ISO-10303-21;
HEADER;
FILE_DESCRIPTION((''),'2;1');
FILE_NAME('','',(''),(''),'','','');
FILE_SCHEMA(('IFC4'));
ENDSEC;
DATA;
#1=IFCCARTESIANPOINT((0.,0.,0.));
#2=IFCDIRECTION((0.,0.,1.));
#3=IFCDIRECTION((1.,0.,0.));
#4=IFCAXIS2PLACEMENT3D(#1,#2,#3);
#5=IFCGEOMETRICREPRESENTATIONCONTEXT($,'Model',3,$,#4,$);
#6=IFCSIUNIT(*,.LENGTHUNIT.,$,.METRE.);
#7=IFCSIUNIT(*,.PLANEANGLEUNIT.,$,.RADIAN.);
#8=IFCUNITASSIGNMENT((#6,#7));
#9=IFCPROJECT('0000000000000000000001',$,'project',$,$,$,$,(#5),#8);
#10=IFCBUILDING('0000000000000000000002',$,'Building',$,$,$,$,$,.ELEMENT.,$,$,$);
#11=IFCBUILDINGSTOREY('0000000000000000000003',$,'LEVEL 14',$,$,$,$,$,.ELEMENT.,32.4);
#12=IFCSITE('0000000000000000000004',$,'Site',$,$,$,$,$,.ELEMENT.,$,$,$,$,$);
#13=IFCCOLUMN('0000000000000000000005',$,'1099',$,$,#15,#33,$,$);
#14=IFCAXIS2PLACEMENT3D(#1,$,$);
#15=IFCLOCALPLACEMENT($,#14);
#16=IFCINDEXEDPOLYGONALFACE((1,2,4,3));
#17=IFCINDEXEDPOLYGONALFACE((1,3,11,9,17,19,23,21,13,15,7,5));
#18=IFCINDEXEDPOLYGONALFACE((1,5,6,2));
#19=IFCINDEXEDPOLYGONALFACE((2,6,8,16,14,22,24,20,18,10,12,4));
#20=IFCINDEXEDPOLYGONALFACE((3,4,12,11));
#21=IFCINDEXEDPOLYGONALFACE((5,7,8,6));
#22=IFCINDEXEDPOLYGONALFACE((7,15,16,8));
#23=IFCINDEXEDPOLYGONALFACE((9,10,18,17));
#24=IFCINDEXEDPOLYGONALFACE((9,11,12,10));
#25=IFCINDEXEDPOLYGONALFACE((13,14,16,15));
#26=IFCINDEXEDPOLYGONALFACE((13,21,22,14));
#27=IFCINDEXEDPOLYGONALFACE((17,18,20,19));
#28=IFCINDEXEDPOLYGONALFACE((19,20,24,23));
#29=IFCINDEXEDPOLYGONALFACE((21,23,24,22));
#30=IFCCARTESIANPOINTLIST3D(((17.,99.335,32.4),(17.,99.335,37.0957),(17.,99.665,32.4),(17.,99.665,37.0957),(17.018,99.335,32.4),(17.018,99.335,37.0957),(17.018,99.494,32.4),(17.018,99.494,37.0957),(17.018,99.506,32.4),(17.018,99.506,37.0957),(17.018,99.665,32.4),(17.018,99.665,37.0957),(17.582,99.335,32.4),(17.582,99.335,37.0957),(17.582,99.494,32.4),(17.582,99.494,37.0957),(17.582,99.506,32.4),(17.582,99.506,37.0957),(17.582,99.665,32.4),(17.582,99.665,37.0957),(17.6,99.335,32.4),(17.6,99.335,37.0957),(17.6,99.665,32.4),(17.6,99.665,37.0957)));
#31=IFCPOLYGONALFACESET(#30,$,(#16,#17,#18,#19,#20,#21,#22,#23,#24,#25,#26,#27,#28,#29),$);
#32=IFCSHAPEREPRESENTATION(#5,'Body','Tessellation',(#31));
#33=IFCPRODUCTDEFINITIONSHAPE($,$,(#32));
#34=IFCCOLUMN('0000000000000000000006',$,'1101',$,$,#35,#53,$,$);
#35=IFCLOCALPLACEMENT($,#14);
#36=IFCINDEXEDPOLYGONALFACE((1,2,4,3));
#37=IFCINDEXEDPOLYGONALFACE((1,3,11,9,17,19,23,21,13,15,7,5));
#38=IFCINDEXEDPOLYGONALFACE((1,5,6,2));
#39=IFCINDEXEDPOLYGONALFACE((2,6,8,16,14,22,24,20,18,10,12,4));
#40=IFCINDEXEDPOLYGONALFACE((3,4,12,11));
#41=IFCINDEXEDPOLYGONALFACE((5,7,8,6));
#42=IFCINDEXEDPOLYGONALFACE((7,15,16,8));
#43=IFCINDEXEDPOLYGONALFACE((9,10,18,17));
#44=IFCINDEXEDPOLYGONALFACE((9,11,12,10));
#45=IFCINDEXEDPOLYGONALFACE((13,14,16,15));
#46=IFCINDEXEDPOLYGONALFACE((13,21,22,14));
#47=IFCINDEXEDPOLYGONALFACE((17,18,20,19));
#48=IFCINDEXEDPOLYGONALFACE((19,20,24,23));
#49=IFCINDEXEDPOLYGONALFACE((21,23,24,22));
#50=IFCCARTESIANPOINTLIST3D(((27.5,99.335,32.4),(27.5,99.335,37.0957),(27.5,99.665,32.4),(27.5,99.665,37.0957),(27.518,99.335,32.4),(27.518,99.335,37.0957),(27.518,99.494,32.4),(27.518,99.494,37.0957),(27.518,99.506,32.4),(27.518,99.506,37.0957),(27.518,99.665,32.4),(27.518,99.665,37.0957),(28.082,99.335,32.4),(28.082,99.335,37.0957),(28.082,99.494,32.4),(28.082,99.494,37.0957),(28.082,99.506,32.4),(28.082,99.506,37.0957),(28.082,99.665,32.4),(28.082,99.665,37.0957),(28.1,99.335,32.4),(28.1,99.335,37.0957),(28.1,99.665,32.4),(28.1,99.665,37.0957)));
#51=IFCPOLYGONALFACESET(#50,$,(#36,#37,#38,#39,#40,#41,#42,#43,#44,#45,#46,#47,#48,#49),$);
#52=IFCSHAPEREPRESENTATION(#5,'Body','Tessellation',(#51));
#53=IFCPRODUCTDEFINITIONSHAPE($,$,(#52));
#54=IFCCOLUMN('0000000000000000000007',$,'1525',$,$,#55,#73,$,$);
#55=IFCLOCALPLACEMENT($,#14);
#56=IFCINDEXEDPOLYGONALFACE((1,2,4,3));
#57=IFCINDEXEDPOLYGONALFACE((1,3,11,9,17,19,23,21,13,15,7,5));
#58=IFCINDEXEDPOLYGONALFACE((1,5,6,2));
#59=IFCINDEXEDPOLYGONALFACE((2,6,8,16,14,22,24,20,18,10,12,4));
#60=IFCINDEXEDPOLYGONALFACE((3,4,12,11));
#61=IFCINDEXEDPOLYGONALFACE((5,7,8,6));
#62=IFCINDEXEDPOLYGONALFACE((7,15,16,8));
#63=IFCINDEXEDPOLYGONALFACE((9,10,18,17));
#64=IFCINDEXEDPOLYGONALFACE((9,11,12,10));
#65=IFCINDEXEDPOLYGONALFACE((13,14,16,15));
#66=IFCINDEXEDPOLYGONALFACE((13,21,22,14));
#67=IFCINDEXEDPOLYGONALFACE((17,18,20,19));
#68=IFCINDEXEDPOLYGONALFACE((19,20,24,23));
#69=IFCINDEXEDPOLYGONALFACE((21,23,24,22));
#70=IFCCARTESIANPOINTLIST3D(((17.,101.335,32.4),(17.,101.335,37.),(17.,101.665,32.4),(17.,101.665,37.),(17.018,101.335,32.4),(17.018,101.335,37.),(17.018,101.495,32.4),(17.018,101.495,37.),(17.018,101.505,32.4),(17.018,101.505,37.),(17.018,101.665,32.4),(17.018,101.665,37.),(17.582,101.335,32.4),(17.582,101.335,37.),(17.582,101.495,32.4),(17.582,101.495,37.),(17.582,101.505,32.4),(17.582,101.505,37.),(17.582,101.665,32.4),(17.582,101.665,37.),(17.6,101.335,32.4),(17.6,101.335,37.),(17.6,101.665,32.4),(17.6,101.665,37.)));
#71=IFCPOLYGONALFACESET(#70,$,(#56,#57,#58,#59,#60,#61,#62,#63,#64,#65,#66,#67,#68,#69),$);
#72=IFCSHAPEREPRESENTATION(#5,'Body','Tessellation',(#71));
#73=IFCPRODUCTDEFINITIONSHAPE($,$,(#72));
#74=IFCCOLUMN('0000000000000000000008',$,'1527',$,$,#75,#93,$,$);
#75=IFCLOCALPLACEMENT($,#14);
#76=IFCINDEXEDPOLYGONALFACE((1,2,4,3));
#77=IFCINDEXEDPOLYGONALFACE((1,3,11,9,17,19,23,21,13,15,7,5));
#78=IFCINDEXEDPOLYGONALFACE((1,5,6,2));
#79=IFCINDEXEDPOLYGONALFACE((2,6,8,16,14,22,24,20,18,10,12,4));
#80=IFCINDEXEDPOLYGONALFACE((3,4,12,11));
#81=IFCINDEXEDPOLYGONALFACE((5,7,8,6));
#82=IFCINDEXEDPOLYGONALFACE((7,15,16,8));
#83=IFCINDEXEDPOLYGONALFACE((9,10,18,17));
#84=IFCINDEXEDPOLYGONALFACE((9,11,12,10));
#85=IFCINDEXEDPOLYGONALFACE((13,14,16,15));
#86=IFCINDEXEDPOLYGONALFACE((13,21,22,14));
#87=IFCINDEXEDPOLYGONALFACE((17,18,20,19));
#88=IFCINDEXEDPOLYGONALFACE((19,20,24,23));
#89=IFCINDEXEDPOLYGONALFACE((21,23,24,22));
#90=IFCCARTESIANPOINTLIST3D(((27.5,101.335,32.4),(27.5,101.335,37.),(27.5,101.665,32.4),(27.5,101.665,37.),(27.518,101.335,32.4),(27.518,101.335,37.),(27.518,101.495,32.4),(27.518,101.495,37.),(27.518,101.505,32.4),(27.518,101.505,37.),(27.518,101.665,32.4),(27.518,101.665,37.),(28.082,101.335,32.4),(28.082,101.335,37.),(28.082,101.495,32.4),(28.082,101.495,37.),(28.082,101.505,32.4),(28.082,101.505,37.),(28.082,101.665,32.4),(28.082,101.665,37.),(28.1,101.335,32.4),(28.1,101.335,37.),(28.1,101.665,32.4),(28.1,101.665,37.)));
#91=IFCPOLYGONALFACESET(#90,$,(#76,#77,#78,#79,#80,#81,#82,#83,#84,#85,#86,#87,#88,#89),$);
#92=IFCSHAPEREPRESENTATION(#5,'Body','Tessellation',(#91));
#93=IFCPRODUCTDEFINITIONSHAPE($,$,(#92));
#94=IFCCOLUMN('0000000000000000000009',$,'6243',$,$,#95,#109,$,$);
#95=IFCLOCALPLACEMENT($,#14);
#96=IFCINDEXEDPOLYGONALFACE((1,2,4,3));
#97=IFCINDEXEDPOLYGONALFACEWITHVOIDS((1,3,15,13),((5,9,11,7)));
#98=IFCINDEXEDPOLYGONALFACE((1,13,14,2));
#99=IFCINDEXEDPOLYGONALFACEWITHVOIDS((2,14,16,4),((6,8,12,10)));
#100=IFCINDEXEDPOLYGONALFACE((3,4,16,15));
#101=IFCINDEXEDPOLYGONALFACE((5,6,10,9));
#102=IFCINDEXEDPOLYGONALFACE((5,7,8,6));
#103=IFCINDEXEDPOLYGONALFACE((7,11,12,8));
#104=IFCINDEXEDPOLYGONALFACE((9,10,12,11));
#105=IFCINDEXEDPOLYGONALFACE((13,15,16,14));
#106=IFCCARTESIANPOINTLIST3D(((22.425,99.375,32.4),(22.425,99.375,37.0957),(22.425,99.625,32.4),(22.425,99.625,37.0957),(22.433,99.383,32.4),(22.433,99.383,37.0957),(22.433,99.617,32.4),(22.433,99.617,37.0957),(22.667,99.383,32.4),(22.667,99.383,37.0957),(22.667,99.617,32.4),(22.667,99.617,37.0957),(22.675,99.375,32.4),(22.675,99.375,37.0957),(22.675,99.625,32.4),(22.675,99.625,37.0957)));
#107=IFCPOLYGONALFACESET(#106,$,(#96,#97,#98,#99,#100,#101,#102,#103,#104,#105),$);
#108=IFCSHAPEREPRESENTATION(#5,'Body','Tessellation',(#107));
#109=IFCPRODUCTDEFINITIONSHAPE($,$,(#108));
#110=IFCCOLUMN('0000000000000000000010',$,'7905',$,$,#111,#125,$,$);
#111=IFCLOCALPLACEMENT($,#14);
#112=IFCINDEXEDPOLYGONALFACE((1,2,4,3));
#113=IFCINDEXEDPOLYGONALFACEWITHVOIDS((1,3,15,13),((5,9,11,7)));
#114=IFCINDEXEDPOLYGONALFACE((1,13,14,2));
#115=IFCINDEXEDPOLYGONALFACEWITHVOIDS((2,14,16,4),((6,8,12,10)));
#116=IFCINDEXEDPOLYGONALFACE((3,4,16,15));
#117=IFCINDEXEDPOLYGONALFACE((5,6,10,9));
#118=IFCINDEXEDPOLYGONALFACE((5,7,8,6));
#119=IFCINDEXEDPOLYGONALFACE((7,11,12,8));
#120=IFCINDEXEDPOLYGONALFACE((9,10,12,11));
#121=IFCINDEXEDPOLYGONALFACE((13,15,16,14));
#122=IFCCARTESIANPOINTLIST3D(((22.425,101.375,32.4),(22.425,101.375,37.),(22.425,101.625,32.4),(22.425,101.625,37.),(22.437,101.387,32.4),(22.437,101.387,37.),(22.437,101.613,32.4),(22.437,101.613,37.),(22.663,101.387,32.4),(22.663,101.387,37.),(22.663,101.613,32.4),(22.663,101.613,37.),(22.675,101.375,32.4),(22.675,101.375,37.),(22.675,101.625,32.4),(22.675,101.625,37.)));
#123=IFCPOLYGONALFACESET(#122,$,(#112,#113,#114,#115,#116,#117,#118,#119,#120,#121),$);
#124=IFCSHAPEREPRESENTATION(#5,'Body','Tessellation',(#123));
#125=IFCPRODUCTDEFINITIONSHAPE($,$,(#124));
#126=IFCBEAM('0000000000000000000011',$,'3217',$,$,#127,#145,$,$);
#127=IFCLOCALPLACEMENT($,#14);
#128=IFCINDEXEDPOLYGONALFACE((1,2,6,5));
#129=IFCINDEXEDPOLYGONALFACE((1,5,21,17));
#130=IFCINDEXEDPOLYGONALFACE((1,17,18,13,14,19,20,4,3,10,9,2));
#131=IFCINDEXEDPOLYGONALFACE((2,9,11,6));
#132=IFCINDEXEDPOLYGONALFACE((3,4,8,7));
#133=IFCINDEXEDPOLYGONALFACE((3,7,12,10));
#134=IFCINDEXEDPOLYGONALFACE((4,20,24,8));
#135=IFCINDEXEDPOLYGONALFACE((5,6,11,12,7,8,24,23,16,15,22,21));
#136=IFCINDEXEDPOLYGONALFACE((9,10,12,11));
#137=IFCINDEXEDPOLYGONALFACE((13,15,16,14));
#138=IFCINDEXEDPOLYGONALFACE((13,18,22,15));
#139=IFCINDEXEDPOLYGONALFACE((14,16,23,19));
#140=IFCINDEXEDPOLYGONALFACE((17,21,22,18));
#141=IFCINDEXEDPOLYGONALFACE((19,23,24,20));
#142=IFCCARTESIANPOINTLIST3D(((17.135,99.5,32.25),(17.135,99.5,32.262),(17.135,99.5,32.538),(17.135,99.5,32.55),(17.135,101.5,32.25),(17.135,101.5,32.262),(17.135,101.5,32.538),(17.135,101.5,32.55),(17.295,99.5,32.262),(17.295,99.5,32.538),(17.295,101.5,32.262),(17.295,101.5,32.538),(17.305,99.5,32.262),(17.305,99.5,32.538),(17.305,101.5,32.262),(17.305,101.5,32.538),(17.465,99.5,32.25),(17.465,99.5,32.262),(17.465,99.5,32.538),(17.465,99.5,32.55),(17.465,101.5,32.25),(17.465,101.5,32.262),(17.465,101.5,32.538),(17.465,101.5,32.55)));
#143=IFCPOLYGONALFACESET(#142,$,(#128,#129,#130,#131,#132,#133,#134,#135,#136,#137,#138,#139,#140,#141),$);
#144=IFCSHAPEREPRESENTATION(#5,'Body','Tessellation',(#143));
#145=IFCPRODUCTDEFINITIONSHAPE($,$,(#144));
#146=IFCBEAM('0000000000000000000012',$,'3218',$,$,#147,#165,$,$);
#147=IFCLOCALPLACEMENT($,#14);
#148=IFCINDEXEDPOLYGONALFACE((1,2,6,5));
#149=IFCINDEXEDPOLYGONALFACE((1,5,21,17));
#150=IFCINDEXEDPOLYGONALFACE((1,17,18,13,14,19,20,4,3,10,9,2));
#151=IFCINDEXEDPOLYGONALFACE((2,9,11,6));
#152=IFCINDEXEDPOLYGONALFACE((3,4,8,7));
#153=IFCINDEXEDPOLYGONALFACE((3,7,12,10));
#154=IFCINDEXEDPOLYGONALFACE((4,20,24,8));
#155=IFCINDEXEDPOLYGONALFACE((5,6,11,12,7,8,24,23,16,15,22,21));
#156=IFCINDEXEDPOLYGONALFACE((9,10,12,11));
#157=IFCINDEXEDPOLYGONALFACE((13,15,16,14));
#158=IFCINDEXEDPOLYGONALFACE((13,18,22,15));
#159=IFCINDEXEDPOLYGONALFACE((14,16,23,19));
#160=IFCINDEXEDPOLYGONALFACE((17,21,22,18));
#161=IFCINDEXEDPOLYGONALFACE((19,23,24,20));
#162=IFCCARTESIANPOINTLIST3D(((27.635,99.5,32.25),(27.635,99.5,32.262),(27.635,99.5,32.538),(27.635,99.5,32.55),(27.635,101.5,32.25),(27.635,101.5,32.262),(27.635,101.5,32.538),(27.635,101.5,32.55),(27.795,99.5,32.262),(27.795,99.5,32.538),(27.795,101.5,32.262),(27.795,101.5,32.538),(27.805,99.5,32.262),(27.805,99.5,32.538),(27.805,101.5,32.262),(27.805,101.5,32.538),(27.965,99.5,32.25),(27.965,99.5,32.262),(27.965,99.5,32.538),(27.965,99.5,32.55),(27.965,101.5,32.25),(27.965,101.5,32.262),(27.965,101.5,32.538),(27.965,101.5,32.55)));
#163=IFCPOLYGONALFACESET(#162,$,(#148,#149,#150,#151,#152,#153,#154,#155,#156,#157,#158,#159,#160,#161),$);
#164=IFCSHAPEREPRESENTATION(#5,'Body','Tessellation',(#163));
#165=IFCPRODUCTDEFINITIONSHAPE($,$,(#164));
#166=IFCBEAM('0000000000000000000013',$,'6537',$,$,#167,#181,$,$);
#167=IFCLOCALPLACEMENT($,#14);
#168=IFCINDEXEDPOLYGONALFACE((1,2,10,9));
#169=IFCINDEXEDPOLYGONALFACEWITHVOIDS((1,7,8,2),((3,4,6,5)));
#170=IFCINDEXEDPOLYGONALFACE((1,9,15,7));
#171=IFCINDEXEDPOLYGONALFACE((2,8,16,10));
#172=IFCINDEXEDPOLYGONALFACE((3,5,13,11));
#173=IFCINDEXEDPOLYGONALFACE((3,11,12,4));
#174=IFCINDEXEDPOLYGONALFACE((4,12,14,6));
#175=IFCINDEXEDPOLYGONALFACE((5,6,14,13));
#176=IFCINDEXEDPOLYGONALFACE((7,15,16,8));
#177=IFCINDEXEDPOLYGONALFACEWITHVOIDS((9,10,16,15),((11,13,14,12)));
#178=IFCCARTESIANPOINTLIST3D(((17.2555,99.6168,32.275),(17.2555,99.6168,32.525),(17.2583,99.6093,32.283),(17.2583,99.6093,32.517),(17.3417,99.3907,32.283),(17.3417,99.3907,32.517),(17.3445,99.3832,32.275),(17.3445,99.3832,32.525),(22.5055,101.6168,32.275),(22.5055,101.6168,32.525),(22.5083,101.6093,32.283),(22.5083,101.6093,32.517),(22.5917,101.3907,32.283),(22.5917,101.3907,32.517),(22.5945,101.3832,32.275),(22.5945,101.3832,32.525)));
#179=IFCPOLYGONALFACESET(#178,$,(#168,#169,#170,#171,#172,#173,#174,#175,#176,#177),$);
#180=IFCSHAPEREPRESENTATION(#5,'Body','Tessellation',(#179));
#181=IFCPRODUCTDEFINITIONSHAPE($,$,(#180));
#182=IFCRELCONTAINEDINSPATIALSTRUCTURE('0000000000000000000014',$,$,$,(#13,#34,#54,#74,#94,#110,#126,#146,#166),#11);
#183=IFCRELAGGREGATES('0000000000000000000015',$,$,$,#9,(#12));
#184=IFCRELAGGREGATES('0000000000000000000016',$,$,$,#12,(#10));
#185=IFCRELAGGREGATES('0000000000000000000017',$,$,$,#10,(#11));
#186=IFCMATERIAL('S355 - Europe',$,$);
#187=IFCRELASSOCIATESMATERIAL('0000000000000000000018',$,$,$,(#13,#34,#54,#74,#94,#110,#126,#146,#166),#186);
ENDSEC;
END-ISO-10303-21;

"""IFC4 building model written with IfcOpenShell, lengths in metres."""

from ifc_helpers import new_model, si_unit, frame, origin_with_axes, origin_2d_with_axis, place, context, project, spatial, hollow_rectangle, i_section, extrude, material, material_profile, profile_set, profile_usage, element, save


model = new_model("IFC4")

# Units and contexts
model_context = context("Model", 3, world=origin_with_axes())
ifc_project = project(units=[si_unit("LENGTHUNIT", "METRE"), si_unit("PLANEANGLEUNIT", "RADIAN")], contexts=[model_context])

# Site, building, storey
site = spatial("IfcSite", under=ifc_project, Name="Site", CompositionType="ELEMENT")
building = spatial("IfcBuilding", under=site, Name="Building", CompositionType="ELEMENT")
storey = spatial("IfcBuildingStorey", under=building, Name="LEVEL 14", CompositionType="ELEMENT", Elevation=32.4)

# Columns
ifc_material = material(Name="S355 - Europe")
ifc_material_profile_1 = material_profile(ifc_material, i_section(OverallWidth=0.33, OverallDepth=0.6, WebThickness=0.012, FlangeThickness=0.018, at=origin_2d_with_axis()))
ifc_profile_set_1 = profile_set([ifc_material_profile_1])
ifc_profile_usage_1 = profile_usage(ifc_profile_set_1, cardinal=10)
column_1_placement = place(None, frame((17.3, 99.5, 32.4), z_axis=(0.0, 0.0, 1.0), x_axis=(0.0, -1.0, 0.0)))
element("IfcColumn", 1, at=column_1_placement, inside=storey, material=ifc_profile_usage_1, Name="1099", context=model_context, shape_type="SweptSolid", body=[
    extrude(i_section(OverallWidth=0.33, OverallDepth=0.6, WebThickness=0.012, FlangeThickness=0.018, at=origin_2d_with_axis()), origin_with_axes(), (0.0, 0.0, 1.0), 4.6957),
])
ifc_material_profile_2 = material_profile(ifc_material, i_section(OverallWidth=0.33, OverallDepth=0.6, WebThickness=0.012, FlangeThickness=0.018, at=origin_2d_with_axis()))
ifc_profile_set_2 = profile_set([ifc_material_profile_2])
ifc_profile_usage_2 = profile_usage(ifc_profile_set_2, cardinal=10)
column_2_placement = place(None, frame((27.8, 99.5, 32.4), z_axis=(0.0, 0.0, 1.0), x_axis=(0.0, -1.0, 0.0)))
element("IfcColumn", 2, at=column_2_placement, inside=storey, material=ifc_profile_usage_2, Name="1101", context=model_context, shape_type="SweptSolid", body=[
    extrude(i_section(OverallWidth=0.33, OverallDepth=0.6, WebThickness=0.012, FlangeThickness=0.018, at=origin_2d_with_axis()), origin_with_axes(), (0.0, 0.0, 1.0), 4.6957),
])
ifc_material_profile_3 = material_profile(ifc_material, i_section(OverallWidth=0.33, OverallDepth=0.6, WebThickness=0.01, FlangeThickness=0.018, at=origin_2d_with_axis()))
ifc_profile_set_3 = profile_set([ifc_material_profile_3])
ifc_profile_usage_3 = profile_usage(ifc_profile_set_3, cardinal=10)
column_3_placement = place(None, frame((17.3, 101.5, 32.4), z_axis=(0.0, 0.0, 1.0), x_axis=(0.0, -1.0, 0.0)))
element("IfcColumn", 3, at=column_3_placement, inside=storey, material=ifc_profile_usage_3, Name="1525", context=model_context, shape_type="SweptSolid", body=[
    extrude(i_section(OverallWidth=0.33, OverallDepth=0.6, WebThickness=0.01, FlangeThickness=0.018, at=origin_2d_with_axis()), origin_with_axes(), (0.0, 0.0, 1.0), 4.6),
])
ifc_material_profile_4 = material_profile(ifc_material, i_section(OverallWidth=0.33, OverallDepth=0.6, WebThickness=0.01, FlangeThickness=0.018, at=origin_2d_with_axis()))
ifc_profile_set_4 = profile_set([ifc_material_profile_4])
ifc_profile_usage_4 = profile_usage(ifc_profile_set_4, cardinal=10)
column_4_placement = place(None, frame((27.8, 101.5, 32.4), z_axis=(0.0, 0.0, 1.0), x_axis=(0.0, -1.0, 0.0)))
element("IfcColumn", 4, at=column_4_placement, inside=storey, material=ifc_profile_usage_4, Name="1527", context=model_context, shape_type="SweptSolid", body=[
    extrude(i_section(OverallWidth=0.33, OverallDepth=0.6, WebThickness=0.01, FlangeThickness=0.018, at=origin_2d_with_axis()), origin_with_axes(), (0.0, 0.0, 1.0), 4.6),
])
ifc_material_profile_5 = material_profile(ifc_material, hollow_rectangle(XDim=0.25, YDim=0.25, WallThickness=0.008, at=origin_2d_with_axis()))
ifc_profile_set_5 = profile_set([ifc_material_profile_5])
ifc_profile_usage_5 = profile_usage(ifc_profile_set_5, cardinal=10)
column_5_placement = place(None, frame((22.55, 99.5, 32.4), z_axis=(0.0, 0.0, 1.0), x_axis=(0.0, -1.0, 0.0)))
element("IfcColumn", 5, at=column_5_placement, inside=storey, material=ifc_profile_usage_5, Name="6243", context=model_context, shape_type="SweptSolid", body=[
    extrude(hollow_rectangle(XDim=0.25, YDim=0.25, WallThickness=0.008, at=origin_2d_with_axis()), origin_with_axes(), (0.0, 0.0, 1.0), 4.6957),
])
ifc_material_profile_6 = material_profile(ifc_material, hollow_rectangle(XDim=0.25, YDim=0.25, WallThickness=0.012, at=origin_2d_with_axis()))
ifc_profile_set_6 = profile_set([ifc_material_profile_6])
ifc_profile_usage_6 = profile_usage(ifc_profile_set_6, cardinal=10)
column_6_placement = place(None, frame((22.55, 101.5, 32.4), z_axis=(0.0, 0.0, 1.0), x_axis=(0.0, -1.0, 0.0)))
element("IfcColumn", 6, at=column_6_placement, inside=storey, material=ifc_profile_usage_6, Name="7905", context=model_context, shape_type="SweptSolid", body=[
    extrude(hollow_rectangle(XDim=0.25, YDim=0.25, WallThickness=0.012, at=origin_2d_with_axis()), origin_with_axes(), (0.0, 0.0, 1.0), 4.6),
])

# Beams
ifc_material_profile_7 = material_profile(ifc_material, i_section(OverallWidth=0.33, OverallDepth=0.3, WebThickness=0.01, FlangeThickness=0.012, at=origin_2d_with_axis()))
ifc_profile_set_7 = profile_set([ifc_material_profile_7])
ifc_profile_usage_7 = profile_usage(ifc_profile_set_7, cardinal=10)
beam_1_placement = place(None, frame((17.3, 101.5, 32.4), z_axis=(0.0, -1.0, 0.0), x_axis=(1.0, 0.0, 0.0)))
element("IfcBeam", 7, at=beam_1_placement, inside=storey, material=ifc_profile_usage_7, Name="3217", context=model_context, shape_type="SweptSolid", body=[
    extrude(i_section(OverallWidth=0.33, OverallDepth=0.3, WebThickness=0.01, FlangeThickness=0.012, at=origin_2d_with_axis()), origin_with_axes(), (0.0, 0.0, 1.0), 2.0),
])
ifc_material_profile_8 = material_profile(ifc_material, i_section(OverallWidth=0.33, OverallDepth=0.3, WebThickness=0.01, FlangeThickness=0.012, at=origin_2d_with_axis()))
ifc_profile_set_8 = profile_set([ifc_material_profile_8])
ifc_profile_usage_8 = profile_usage(ifc_profile_set_8, cardinal=10)
beam_2_placement = place(None, frame((27.8, 101.5, 32.4), z_axis=(0.0, -1.0, 0.0), x_axis=(1.0, 0.0, 0.0)))
element("IfcBeam", 8, at=beam_2_placement, inside=storey, material=ifc_profile_usage_8, Name="3218", context=model_context, shape_type="SweptSolid", body=[
    extrude(i_section(OverallWidth=0.33, OverallDepth=0.3, WebThickness=0.01, FlangeThickness=0.012, at=origin_2d_with_axis()), origin_with_axes(), (0.0, 0.0, 1.0), 2.0),
])
ifc_material_profile_9 = material_profile(ifc_material, hollow_rectangle(XDim=0.25, YDim=0.25, WallThickness=0.008, at=origin_2d_with_axis()))
ifc_profile_set_9 = profile_set([ifc_material_profile_9])
ifc_profile_usage_9 = profile_usage(ifc_profile_set_9, cardinal=10)
beam_3_placement = place(None, frame((17.3, 99.5, 32.4), z_axis=(0.934488, 0.355995, 0.0), x_axis=(-0.355995, 0.934488, 0.0)))
element("IfcBeam", 9, at=beam_3_placement, inside=storey, material=ifc_profile_usage_9, Name="6537", context=model_context, shape_type="SweptSolid", body=[
    extrude(hollow_rectangle(XDim=0.25, YDim=0.25, WallThickness=0.008, at=origin_2d_with_axis()), origin_with_axes(), (0.0, 0.0, 1.0), 5.6181),
])

save(model, "model.ifc")
